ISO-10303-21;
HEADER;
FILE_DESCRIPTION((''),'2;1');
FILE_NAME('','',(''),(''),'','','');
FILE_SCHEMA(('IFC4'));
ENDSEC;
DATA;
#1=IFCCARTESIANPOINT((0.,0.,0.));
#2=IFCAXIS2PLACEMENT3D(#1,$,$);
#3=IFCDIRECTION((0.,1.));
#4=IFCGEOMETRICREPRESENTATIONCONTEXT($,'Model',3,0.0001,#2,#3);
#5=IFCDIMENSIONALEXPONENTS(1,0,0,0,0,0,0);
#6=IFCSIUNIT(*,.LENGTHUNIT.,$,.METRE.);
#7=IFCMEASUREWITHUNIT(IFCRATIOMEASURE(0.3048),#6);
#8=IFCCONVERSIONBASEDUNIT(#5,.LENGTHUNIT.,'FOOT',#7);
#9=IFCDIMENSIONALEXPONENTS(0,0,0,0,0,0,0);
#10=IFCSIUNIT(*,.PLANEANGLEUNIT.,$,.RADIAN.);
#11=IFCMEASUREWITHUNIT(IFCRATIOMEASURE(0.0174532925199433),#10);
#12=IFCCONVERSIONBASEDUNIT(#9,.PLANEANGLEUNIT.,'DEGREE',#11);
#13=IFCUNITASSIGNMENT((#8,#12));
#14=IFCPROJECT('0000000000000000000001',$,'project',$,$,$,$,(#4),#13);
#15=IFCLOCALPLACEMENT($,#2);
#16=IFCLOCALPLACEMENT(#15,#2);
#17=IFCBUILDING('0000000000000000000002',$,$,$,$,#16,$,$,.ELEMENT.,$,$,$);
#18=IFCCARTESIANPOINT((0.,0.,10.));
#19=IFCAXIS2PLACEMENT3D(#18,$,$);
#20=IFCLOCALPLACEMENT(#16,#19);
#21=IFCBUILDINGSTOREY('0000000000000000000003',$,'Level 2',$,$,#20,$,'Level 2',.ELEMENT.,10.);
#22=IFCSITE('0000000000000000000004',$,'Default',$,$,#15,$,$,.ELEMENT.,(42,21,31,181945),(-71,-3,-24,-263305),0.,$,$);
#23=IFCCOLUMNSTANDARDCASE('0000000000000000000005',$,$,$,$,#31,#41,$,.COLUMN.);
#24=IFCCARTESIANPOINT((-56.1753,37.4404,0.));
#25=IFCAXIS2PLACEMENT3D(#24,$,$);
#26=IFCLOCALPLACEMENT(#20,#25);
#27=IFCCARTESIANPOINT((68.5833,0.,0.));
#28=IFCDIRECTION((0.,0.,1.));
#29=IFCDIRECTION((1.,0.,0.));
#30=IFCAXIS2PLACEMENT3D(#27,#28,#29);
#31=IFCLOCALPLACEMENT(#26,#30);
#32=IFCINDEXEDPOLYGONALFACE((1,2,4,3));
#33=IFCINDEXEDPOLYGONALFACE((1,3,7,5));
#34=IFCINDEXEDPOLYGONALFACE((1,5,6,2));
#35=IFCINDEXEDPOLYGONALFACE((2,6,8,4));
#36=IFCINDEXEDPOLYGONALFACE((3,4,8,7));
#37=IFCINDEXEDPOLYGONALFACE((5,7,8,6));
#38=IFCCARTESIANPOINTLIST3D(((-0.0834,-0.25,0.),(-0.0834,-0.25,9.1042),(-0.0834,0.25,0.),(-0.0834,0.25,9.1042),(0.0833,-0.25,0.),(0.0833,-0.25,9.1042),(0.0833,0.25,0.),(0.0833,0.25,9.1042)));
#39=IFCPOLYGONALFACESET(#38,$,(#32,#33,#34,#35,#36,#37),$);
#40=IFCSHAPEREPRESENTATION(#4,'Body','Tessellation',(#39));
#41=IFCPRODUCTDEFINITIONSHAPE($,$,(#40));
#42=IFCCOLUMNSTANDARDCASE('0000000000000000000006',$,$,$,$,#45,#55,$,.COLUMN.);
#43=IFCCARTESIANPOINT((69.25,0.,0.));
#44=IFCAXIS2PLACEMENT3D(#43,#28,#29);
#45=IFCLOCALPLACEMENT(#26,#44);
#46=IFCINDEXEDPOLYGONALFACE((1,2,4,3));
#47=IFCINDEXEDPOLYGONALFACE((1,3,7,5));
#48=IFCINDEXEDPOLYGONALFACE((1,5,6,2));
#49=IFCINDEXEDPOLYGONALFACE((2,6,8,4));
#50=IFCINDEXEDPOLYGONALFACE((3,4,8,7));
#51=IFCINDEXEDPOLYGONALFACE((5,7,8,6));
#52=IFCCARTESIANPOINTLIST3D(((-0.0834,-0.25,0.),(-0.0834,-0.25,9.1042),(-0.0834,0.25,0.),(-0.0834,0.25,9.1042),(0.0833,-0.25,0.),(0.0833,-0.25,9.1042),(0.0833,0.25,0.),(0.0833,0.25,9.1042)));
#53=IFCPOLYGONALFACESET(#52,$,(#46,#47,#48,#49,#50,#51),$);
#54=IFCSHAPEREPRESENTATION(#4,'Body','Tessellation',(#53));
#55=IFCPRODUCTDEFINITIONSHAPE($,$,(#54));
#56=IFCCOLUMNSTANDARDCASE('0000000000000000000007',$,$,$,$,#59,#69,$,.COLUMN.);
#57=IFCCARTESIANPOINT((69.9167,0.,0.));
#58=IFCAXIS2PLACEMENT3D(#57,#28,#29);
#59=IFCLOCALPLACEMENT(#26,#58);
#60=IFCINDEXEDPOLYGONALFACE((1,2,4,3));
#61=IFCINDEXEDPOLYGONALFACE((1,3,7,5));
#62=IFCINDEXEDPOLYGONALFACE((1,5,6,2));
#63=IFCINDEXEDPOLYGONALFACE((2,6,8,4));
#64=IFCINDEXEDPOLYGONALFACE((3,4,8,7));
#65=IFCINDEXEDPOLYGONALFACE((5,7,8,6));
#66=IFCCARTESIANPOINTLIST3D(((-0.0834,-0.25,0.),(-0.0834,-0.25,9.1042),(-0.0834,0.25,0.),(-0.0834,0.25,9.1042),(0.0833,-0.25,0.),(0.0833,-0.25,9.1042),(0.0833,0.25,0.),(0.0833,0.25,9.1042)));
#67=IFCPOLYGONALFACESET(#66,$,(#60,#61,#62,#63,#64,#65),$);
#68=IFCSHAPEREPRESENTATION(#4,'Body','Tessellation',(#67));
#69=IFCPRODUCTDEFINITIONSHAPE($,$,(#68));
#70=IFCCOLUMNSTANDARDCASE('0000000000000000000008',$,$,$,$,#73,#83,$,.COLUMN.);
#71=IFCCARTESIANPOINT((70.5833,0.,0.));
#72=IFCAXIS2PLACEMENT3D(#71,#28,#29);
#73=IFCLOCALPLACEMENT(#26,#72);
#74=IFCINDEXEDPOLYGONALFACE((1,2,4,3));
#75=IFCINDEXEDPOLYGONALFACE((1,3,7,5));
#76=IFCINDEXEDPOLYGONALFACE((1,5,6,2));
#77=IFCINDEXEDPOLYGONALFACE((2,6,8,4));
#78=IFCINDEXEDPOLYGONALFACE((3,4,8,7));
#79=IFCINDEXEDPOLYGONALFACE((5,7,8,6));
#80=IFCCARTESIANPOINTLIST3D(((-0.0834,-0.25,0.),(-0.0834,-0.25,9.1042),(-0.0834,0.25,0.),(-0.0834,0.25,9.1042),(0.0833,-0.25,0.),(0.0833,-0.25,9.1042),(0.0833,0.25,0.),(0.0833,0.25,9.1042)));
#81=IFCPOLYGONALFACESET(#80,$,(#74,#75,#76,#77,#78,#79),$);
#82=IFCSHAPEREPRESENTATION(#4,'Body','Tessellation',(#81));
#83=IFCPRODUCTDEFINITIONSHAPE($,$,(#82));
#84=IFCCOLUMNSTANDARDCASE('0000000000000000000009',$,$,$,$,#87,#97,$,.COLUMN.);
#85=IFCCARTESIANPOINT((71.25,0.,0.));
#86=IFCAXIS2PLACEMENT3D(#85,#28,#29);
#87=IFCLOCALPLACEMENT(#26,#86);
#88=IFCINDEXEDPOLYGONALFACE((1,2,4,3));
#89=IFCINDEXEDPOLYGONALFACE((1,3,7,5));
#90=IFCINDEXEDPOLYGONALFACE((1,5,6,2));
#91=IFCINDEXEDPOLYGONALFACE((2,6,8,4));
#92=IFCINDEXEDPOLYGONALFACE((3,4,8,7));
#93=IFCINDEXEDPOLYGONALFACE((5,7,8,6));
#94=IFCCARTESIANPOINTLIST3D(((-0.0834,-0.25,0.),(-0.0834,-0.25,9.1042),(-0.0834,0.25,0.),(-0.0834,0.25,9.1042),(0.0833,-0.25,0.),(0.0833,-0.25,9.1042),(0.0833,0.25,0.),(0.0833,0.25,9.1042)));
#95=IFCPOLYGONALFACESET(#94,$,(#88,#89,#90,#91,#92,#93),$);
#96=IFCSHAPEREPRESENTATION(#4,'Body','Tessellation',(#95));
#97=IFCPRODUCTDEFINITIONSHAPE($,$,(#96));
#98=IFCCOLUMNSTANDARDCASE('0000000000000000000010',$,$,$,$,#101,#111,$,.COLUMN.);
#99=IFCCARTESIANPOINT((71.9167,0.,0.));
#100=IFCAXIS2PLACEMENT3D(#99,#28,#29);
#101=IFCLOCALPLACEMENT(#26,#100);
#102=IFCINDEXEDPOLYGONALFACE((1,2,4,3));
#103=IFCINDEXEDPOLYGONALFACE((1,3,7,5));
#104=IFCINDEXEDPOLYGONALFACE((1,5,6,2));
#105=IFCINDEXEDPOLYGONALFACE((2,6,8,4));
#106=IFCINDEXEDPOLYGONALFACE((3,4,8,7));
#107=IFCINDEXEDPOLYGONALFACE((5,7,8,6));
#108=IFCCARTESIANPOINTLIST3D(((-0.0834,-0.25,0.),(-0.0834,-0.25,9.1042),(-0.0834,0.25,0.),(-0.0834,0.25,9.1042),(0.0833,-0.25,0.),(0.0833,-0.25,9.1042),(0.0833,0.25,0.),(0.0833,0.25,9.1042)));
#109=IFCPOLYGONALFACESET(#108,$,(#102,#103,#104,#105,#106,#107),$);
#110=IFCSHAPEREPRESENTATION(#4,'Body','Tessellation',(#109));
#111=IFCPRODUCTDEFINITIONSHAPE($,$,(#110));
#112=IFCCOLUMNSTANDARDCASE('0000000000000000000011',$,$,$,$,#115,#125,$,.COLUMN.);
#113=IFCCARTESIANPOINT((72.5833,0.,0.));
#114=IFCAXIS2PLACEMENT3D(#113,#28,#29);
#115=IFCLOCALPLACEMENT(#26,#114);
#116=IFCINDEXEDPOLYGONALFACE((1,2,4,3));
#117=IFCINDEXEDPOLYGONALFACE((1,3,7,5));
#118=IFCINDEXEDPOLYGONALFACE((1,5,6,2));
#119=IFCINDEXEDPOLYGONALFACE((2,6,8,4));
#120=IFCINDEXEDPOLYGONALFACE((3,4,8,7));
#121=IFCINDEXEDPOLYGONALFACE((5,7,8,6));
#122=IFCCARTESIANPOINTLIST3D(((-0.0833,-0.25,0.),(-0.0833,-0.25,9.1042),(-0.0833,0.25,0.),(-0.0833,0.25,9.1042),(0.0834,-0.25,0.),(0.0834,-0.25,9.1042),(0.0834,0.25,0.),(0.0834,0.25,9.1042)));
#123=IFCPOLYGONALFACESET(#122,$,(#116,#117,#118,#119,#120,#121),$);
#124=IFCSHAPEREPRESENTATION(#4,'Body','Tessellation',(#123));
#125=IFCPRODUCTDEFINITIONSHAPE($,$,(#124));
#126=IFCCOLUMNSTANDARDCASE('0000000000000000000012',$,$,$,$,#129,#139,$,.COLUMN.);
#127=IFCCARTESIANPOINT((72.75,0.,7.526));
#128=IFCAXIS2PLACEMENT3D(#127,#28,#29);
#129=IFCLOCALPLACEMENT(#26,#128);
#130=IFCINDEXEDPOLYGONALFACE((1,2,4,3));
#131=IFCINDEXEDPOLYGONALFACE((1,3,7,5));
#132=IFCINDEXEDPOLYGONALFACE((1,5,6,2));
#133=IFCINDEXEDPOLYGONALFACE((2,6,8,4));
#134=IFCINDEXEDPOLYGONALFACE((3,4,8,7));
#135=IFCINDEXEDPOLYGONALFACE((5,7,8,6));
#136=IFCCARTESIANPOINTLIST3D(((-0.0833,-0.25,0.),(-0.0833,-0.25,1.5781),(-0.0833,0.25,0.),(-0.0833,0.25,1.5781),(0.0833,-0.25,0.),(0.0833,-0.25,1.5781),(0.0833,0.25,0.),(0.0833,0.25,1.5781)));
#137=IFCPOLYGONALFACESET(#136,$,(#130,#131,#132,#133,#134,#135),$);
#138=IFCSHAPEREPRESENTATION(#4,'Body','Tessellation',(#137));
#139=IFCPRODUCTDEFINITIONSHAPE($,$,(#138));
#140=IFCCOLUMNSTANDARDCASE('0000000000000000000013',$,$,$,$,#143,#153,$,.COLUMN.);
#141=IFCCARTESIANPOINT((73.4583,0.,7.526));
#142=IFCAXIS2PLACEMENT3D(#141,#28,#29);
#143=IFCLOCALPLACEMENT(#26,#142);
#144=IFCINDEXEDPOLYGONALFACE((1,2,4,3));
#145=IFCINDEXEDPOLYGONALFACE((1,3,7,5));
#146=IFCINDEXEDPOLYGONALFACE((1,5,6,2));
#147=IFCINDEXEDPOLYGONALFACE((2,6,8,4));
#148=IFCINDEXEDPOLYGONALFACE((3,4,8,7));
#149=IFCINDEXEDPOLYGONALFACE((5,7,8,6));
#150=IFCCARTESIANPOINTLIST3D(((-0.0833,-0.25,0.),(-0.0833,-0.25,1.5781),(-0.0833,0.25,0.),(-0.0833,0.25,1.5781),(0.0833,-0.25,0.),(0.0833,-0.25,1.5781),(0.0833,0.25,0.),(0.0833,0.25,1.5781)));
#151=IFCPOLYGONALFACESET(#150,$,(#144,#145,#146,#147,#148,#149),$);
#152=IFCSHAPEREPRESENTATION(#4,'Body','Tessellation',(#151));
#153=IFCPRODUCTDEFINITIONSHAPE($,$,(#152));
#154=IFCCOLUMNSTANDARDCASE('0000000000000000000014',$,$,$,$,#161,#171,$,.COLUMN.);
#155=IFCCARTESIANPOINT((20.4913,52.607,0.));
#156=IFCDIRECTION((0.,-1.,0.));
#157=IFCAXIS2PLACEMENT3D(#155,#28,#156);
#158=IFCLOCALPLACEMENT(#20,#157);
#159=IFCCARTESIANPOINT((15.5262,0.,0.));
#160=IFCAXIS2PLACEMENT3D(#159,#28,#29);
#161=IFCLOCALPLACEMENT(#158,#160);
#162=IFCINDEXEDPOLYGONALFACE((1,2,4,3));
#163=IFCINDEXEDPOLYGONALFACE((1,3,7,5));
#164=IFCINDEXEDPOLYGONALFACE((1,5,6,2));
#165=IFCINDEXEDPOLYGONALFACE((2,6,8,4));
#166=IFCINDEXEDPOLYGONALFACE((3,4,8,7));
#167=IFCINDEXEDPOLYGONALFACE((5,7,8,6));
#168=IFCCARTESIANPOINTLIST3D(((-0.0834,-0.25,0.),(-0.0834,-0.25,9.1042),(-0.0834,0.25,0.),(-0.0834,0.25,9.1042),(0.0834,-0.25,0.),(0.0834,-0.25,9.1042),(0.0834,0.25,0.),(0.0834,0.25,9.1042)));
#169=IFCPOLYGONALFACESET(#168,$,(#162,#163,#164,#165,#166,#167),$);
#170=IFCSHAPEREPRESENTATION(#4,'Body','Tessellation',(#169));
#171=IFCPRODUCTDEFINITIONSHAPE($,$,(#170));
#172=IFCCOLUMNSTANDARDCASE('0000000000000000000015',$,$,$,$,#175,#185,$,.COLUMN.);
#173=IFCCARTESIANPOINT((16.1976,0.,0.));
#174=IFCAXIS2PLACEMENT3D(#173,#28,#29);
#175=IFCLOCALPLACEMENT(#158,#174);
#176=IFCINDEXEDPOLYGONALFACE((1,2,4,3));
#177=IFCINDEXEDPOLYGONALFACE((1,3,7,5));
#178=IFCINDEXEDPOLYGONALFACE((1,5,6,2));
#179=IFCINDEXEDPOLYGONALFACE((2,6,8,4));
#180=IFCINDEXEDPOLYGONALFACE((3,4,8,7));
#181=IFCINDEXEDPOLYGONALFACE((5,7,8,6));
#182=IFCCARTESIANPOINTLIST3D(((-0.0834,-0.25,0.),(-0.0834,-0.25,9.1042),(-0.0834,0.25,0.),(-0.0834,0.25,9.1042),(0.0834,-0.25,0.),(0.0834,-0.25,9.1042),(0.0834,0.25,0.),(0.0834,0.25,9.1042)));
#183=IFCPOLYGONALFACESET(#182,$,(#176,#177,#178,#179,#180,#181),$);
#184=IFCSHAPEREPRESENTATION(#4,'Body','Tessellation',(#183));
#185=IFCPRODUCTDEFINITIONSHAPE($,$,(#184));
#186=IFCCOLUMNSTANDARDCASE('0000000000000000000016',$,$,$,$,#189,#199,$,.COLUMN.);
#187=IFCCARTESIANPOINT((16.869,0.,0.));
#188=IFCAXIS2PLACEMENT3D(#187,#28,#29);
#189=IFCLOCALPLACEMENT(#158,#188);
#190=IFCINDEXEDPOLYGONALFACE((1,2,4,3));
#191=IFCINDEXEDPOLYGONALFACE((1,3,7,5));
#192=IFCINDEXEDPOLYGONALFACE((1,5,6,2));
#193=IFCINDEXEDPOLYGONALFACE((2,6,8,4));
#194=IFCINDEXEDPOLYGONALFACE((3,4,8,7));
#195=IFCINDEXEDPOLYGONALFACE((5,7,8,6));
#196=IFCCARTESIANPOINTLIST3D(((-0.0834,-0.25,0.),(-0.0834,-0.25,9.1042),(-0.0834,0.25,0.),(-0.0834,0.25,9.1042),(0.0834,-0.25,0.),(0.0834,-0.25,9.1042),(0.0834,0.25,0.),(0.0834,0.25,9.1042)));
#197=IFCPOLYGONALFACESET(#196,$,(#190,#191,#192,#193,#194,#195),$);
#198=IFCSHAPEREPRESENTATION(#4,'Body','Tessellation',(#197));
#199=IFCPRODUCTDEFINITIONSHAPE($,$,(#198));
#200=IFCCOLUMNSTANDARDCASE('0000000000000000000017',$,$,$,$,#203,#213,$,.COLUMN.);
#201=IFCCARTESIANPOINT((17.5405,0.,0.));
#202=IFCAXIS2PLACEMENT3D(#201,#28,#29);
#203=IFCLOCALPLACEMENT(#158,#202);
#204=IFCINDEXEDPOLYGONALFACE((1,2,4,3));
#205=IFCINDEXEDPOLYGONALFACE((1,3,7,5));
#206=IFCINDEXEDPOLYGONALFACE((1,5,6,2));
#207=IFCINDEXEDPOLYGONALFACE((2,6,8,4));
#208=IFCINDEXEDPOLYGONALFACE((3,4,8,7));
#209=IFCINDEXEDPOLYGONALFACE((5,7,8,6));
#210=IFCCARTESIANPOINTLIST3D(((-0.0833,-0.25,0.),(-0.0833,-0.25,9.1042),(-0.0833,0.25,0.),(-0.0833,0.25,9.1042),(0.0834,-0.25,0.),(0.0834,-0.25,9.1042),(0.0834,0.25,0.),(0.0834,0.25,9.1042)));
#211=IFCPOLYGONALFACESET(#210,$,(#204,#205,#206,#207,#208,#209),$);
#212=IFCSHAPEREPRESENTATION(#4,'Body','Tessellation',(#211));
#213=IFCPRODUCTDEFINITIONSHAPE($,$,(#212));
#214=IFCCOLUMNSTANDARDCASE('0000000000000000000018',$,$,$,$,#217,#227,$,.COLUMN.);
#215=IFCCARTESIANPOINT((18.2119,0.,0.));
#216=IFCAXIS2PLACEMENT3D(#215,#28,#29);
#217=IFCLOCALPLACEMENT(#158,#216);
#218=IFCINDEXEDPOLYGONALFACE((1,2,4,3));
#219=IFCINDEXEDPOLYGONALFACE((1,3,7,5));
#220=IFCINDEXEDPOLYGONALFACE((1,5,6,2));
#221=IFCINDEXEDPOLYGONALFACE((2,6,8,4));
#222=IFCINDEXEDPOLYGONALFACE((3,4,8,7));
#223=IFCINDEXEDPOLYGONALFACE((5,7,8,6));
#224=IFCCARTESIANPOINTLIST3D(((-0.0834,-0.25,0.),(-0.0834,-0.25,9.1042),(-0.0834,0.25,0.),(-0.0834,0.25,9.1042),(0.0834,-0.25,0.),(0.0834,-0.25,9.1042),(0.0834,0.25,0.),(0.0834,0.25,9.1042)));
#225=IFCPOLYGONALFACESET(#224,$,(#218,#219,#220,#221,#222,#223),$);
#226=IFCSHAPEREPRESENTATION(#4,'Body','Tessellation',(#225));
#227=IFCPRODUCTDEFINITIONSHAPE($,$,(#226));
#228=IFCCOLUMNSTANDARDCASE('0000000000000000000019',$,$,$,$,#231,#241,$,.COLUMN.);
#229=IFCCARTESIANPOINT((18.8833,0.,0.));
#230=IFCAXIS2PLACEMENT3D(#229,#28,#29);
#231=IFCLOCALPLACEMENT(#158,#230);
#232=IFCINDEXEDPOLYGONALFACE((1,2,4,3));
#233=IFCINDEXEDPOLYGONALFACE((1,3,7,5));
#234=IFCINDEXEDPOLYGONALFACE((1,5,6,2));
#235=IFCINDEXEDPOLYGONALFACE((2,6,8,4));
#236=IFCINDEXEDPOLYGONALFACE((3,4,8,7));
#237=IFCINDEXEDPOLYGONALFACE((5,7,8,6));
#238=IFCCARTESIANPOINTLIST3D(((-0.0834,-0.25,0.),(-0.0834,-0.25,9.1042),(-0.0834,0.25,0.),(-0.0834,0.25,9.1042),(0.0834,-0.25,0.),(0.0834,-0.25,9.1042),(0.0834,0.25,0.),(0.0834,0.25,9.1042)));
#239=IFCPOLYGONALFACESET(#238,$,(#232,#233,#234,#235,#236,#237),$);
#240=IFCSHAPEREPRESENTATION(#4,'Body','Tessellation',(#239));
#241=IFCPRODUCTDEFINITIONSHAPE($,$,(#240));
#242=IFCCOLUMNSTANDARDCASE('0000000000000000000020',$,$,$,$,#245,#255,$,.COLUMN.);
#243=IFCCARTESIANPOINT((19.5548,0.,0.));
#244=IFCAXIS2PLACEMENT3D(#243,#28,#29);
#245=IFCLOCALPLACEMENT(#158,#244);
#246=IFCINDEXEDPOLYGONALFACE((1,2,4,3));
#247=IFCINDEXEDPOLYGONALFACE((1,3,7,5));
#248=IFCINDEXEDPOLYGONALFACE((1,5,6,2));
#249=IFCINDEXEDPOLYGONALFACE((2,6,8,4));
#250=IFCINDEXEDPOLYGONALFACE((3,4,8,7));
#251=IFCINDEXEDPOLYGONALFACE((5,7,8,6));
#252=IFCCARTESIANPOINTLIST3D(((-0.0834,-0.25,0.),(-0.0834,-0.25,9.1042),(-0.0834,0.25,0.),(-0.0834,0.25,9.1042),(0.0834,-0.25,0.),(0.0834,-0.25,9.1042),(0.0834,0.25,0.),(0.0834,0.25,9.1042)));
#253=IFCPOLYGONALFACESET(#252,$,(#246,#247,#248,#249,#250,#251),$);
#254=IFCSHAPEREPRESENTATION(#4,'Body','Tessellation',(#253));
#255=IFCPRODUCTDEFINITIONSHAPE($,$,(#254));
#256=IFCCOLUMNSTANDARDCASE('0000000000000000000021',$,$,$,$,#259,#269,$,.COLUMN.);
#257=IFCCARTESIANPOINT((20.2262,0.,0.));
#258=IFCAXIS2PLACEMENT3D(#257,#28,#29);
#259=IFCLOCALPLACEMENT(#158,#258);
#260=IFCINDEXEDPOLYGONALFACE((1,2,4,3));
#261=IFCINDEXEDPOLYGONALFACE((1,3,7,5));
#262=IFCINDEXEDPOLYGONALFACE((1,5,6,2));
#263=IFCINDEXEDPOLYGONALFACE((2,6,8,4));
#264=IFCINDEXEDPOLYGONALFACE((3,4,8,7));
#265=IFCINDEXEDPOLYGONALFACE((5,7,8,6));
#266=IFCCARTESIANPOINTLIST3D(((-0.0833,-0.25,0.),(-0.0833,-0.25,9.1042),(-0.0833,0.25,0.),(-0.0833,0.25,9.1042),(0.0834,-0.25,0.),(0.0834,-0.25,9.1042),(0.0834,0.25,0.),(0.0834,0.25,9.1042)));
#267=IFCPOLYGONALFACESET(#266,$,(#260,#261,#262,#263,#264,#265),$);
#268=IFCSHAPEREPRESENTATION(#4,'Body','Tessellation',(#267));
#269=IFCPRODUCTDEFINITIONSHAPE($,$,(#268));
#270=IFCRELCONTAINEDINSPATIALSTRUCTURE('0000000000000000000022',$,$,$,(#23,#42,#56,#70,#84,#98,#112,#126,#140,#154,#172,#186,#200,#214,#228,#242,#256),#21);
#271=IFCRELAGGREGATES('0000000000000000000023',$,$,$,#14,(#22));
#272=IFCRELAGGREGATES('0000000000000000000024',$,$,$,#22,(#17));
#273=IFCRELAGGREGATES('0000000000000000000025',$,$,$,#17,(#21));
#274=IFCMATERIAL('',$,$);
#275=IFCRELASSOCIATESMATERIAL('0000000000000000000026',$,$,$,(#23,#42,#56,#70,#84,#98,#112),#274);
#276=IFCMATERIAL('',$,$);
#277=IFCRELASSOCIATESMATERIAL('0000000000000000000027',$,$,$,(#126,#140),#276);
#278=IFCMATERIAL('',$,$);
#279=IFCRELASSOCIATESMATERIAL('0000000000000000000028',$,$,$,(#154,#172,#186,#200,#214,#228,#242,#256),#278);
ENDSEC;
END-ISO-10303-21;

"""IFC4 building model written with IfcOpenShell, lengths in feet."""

from ifc_helpers import new_model, entity, si_unit, converted_unit, direction, frame, origin, place, context, project, spatial, rectangle, extrude, material, element, save


model = new_model("IFC4")

# Units and contexts
model_context = context("Model", 3, precision=0.0001, world=origin(), true_north=direction((0.0, 1.0)))
ifc_project = project(units=[converted_unit("LENGTHUNIT", "FOOT", entity("IfcRatioMeasure", 0.3048), si_unit("LENGTHUNIT", "METRE"), dimensions=[1, 0, 0, 0, 0, 0, 0]), converted_unit("PLANEANGLEUNIT", "DEGREE", entity("IfcRatioMeasure", 0.0174532925199433), si_unit("PLANEANGLEUNIT", "RADIAN"), dimensions=[0, 0, 0, 0, 0, 0, 0])], contexts=[model_context])

# Site, building, storey
site_placement = place(None, origin())
site = spatial("IfcSite", under=ifc_project, at=site_placement, Name="Default", CompositionType="ELEMENT", RefLatitude=(42, 21, 31, 181945), RefLongitude=(-71, -3, -24, -263305), RefElevation=0.0)
building_placement = place(site_placement, origin())
building = spatial("IfcBuilding", under=site, at=building_placement, CompositionType="ELEMENT")
storey_placement = place(building_placement, frame((0.0, 0.0, 10.0)))
storey = spatial("IfcBuildingStorey", under=building, at=storey_placement, Name="Level 2", LongName="Level 2", CompositionType="ELEMENT", Elevation=10.0)

# Columns
ifc_material_1 = material(Name="")
placement_1 = place(storey_placement, frame((-56.1753, 37.4404, 0.0)))
for number, where, z_axis, x_axis in (
    (1, (68.5833, 0.0, 0.0), (0.0, 0.0, 1.0), (1.0, 0.0, 0.0)),
    (2, (69.25, 0.0, 0.0), (0.0, 0.0, 1.0), (1.0, 0.0, 0.0)),
    (3, (69.9167, 0.0, 0.0), (0.0, 0.0, 1.0), (1.0, 0.0, 0.0)),
    (4, (70.5833, 0.0, 0.0), (0.0, 0.0, 1.0), (1.0, 0.0, 0.0)),
    (5, (71.25, 0.0, 0.0), (0.0, 0.0, 1.0), (1.0, 0.0, 0.0)),
    (6, (71.9167, 0.0, 0.0), (0.0, 0.0, 1.0), (1.0, 0.0, 0.0)),
    (7, (72.5833, 0.0, 0.0), (0.0, 0.0, 1.0), (1.0, 0.0, 0.0)),
):
    element("IfcColumnStandardCase", number, at=place(placement_1, frame(where, z_axis=z_axis, x_axis=x_axis)), inside=storey, material=ifc_material_1, PredefinedType="COLUMN", context=model_context, shape_type="SweptSolid", body=[
        extrude(rectangle(XDim=0.1667, YDim=0.5), origin(), (0.0, 0.0, 1.0), 9.1042),
    ])
ifc_material_2 = material(Name="")
for number, where, z_axis, x_axis in (
    (8, (72.75, 0.0, 7.526), (0.0, 0.0, 1.0), (1.0, 0.0, 0.0)),
    (9, (73.4583, 0.0, 7.526), (0.0, 0.0, 1.0), (1.0, 0.0, 0.0)),
):
    element("IfcColumnStandardCase", number, at=place(placement_1, frame(where, z_axis=z_axis, x_axis=x_axis)), inside=storey, material=ifc_material_2, PredefinedType="COLUMN", context=model_context, shape_type="SweptSolid", body=[
        extrude(rectangle(XDim=0.1667, YDim=0.5), origin(), (0.0, 0.0, 1.0), 1.5781),
    ])
ifc_material_3 = material(Name="")
placement_2 = place(storey_placement, frame((20.4913, 52.607, 0.0), z_axis=(0.0, 0.0, 1.0), x_axis=(0.0, -1.0, 0.0)))
for number, where, z_axis, x_axis in (
    (10, (15.5262, 0.0, 0.0), (0.0, 0.0, 1.0), (1.0, 0.0, 0.0)),
    (11, (16.1976, 0.0, 0.0), (0.0, 0.0, 1.0), (1.0, 0.0, 0.0)),
    (12, (16.869, 0.0, 0.0), (0.0, 0.0, 1.0), (1.0, 0.0, 0.0)),
    (13, (17.5405, 0.0, 0.0), (0.0, 0.0, 1.0), (1.0, 0.0, 0.0)),
    (14, (18.2119, 0.0, 0.0), (0.0, 0.0, 1.0), (1.0, 0.0, 0.0)),
    (15, (18.8833, 0.0, 0.0), (0.0, 0.0, 1.0), (1.0, 0.0, 0.0)),
    (16, (19.5548, 0.0, 0.0), (0.0, 0.0, 1.0), (1.0, 0.0, 0.0)),
    (17, (20.2262, 0.0, 0.0), (0.0, 0.0, 1.0), (1.0, 0.0, 0.0)),
):
    element("IfcColumnStandardCase", number, at=place(placement_2, frame(where, z_axis=z_axis, x_axis=x_axis)), inside=storey, material=ifc_material_3, PredefinedType="COLUMN", context=model_context, shape_type="SweptSolid", body=[
        extrude(rectangle(XDim=0.1667, YDim=0.5), origin(), (0.0, 0.0, 1.0), 9.1042),
    ])

save(model, "model.ifc")
